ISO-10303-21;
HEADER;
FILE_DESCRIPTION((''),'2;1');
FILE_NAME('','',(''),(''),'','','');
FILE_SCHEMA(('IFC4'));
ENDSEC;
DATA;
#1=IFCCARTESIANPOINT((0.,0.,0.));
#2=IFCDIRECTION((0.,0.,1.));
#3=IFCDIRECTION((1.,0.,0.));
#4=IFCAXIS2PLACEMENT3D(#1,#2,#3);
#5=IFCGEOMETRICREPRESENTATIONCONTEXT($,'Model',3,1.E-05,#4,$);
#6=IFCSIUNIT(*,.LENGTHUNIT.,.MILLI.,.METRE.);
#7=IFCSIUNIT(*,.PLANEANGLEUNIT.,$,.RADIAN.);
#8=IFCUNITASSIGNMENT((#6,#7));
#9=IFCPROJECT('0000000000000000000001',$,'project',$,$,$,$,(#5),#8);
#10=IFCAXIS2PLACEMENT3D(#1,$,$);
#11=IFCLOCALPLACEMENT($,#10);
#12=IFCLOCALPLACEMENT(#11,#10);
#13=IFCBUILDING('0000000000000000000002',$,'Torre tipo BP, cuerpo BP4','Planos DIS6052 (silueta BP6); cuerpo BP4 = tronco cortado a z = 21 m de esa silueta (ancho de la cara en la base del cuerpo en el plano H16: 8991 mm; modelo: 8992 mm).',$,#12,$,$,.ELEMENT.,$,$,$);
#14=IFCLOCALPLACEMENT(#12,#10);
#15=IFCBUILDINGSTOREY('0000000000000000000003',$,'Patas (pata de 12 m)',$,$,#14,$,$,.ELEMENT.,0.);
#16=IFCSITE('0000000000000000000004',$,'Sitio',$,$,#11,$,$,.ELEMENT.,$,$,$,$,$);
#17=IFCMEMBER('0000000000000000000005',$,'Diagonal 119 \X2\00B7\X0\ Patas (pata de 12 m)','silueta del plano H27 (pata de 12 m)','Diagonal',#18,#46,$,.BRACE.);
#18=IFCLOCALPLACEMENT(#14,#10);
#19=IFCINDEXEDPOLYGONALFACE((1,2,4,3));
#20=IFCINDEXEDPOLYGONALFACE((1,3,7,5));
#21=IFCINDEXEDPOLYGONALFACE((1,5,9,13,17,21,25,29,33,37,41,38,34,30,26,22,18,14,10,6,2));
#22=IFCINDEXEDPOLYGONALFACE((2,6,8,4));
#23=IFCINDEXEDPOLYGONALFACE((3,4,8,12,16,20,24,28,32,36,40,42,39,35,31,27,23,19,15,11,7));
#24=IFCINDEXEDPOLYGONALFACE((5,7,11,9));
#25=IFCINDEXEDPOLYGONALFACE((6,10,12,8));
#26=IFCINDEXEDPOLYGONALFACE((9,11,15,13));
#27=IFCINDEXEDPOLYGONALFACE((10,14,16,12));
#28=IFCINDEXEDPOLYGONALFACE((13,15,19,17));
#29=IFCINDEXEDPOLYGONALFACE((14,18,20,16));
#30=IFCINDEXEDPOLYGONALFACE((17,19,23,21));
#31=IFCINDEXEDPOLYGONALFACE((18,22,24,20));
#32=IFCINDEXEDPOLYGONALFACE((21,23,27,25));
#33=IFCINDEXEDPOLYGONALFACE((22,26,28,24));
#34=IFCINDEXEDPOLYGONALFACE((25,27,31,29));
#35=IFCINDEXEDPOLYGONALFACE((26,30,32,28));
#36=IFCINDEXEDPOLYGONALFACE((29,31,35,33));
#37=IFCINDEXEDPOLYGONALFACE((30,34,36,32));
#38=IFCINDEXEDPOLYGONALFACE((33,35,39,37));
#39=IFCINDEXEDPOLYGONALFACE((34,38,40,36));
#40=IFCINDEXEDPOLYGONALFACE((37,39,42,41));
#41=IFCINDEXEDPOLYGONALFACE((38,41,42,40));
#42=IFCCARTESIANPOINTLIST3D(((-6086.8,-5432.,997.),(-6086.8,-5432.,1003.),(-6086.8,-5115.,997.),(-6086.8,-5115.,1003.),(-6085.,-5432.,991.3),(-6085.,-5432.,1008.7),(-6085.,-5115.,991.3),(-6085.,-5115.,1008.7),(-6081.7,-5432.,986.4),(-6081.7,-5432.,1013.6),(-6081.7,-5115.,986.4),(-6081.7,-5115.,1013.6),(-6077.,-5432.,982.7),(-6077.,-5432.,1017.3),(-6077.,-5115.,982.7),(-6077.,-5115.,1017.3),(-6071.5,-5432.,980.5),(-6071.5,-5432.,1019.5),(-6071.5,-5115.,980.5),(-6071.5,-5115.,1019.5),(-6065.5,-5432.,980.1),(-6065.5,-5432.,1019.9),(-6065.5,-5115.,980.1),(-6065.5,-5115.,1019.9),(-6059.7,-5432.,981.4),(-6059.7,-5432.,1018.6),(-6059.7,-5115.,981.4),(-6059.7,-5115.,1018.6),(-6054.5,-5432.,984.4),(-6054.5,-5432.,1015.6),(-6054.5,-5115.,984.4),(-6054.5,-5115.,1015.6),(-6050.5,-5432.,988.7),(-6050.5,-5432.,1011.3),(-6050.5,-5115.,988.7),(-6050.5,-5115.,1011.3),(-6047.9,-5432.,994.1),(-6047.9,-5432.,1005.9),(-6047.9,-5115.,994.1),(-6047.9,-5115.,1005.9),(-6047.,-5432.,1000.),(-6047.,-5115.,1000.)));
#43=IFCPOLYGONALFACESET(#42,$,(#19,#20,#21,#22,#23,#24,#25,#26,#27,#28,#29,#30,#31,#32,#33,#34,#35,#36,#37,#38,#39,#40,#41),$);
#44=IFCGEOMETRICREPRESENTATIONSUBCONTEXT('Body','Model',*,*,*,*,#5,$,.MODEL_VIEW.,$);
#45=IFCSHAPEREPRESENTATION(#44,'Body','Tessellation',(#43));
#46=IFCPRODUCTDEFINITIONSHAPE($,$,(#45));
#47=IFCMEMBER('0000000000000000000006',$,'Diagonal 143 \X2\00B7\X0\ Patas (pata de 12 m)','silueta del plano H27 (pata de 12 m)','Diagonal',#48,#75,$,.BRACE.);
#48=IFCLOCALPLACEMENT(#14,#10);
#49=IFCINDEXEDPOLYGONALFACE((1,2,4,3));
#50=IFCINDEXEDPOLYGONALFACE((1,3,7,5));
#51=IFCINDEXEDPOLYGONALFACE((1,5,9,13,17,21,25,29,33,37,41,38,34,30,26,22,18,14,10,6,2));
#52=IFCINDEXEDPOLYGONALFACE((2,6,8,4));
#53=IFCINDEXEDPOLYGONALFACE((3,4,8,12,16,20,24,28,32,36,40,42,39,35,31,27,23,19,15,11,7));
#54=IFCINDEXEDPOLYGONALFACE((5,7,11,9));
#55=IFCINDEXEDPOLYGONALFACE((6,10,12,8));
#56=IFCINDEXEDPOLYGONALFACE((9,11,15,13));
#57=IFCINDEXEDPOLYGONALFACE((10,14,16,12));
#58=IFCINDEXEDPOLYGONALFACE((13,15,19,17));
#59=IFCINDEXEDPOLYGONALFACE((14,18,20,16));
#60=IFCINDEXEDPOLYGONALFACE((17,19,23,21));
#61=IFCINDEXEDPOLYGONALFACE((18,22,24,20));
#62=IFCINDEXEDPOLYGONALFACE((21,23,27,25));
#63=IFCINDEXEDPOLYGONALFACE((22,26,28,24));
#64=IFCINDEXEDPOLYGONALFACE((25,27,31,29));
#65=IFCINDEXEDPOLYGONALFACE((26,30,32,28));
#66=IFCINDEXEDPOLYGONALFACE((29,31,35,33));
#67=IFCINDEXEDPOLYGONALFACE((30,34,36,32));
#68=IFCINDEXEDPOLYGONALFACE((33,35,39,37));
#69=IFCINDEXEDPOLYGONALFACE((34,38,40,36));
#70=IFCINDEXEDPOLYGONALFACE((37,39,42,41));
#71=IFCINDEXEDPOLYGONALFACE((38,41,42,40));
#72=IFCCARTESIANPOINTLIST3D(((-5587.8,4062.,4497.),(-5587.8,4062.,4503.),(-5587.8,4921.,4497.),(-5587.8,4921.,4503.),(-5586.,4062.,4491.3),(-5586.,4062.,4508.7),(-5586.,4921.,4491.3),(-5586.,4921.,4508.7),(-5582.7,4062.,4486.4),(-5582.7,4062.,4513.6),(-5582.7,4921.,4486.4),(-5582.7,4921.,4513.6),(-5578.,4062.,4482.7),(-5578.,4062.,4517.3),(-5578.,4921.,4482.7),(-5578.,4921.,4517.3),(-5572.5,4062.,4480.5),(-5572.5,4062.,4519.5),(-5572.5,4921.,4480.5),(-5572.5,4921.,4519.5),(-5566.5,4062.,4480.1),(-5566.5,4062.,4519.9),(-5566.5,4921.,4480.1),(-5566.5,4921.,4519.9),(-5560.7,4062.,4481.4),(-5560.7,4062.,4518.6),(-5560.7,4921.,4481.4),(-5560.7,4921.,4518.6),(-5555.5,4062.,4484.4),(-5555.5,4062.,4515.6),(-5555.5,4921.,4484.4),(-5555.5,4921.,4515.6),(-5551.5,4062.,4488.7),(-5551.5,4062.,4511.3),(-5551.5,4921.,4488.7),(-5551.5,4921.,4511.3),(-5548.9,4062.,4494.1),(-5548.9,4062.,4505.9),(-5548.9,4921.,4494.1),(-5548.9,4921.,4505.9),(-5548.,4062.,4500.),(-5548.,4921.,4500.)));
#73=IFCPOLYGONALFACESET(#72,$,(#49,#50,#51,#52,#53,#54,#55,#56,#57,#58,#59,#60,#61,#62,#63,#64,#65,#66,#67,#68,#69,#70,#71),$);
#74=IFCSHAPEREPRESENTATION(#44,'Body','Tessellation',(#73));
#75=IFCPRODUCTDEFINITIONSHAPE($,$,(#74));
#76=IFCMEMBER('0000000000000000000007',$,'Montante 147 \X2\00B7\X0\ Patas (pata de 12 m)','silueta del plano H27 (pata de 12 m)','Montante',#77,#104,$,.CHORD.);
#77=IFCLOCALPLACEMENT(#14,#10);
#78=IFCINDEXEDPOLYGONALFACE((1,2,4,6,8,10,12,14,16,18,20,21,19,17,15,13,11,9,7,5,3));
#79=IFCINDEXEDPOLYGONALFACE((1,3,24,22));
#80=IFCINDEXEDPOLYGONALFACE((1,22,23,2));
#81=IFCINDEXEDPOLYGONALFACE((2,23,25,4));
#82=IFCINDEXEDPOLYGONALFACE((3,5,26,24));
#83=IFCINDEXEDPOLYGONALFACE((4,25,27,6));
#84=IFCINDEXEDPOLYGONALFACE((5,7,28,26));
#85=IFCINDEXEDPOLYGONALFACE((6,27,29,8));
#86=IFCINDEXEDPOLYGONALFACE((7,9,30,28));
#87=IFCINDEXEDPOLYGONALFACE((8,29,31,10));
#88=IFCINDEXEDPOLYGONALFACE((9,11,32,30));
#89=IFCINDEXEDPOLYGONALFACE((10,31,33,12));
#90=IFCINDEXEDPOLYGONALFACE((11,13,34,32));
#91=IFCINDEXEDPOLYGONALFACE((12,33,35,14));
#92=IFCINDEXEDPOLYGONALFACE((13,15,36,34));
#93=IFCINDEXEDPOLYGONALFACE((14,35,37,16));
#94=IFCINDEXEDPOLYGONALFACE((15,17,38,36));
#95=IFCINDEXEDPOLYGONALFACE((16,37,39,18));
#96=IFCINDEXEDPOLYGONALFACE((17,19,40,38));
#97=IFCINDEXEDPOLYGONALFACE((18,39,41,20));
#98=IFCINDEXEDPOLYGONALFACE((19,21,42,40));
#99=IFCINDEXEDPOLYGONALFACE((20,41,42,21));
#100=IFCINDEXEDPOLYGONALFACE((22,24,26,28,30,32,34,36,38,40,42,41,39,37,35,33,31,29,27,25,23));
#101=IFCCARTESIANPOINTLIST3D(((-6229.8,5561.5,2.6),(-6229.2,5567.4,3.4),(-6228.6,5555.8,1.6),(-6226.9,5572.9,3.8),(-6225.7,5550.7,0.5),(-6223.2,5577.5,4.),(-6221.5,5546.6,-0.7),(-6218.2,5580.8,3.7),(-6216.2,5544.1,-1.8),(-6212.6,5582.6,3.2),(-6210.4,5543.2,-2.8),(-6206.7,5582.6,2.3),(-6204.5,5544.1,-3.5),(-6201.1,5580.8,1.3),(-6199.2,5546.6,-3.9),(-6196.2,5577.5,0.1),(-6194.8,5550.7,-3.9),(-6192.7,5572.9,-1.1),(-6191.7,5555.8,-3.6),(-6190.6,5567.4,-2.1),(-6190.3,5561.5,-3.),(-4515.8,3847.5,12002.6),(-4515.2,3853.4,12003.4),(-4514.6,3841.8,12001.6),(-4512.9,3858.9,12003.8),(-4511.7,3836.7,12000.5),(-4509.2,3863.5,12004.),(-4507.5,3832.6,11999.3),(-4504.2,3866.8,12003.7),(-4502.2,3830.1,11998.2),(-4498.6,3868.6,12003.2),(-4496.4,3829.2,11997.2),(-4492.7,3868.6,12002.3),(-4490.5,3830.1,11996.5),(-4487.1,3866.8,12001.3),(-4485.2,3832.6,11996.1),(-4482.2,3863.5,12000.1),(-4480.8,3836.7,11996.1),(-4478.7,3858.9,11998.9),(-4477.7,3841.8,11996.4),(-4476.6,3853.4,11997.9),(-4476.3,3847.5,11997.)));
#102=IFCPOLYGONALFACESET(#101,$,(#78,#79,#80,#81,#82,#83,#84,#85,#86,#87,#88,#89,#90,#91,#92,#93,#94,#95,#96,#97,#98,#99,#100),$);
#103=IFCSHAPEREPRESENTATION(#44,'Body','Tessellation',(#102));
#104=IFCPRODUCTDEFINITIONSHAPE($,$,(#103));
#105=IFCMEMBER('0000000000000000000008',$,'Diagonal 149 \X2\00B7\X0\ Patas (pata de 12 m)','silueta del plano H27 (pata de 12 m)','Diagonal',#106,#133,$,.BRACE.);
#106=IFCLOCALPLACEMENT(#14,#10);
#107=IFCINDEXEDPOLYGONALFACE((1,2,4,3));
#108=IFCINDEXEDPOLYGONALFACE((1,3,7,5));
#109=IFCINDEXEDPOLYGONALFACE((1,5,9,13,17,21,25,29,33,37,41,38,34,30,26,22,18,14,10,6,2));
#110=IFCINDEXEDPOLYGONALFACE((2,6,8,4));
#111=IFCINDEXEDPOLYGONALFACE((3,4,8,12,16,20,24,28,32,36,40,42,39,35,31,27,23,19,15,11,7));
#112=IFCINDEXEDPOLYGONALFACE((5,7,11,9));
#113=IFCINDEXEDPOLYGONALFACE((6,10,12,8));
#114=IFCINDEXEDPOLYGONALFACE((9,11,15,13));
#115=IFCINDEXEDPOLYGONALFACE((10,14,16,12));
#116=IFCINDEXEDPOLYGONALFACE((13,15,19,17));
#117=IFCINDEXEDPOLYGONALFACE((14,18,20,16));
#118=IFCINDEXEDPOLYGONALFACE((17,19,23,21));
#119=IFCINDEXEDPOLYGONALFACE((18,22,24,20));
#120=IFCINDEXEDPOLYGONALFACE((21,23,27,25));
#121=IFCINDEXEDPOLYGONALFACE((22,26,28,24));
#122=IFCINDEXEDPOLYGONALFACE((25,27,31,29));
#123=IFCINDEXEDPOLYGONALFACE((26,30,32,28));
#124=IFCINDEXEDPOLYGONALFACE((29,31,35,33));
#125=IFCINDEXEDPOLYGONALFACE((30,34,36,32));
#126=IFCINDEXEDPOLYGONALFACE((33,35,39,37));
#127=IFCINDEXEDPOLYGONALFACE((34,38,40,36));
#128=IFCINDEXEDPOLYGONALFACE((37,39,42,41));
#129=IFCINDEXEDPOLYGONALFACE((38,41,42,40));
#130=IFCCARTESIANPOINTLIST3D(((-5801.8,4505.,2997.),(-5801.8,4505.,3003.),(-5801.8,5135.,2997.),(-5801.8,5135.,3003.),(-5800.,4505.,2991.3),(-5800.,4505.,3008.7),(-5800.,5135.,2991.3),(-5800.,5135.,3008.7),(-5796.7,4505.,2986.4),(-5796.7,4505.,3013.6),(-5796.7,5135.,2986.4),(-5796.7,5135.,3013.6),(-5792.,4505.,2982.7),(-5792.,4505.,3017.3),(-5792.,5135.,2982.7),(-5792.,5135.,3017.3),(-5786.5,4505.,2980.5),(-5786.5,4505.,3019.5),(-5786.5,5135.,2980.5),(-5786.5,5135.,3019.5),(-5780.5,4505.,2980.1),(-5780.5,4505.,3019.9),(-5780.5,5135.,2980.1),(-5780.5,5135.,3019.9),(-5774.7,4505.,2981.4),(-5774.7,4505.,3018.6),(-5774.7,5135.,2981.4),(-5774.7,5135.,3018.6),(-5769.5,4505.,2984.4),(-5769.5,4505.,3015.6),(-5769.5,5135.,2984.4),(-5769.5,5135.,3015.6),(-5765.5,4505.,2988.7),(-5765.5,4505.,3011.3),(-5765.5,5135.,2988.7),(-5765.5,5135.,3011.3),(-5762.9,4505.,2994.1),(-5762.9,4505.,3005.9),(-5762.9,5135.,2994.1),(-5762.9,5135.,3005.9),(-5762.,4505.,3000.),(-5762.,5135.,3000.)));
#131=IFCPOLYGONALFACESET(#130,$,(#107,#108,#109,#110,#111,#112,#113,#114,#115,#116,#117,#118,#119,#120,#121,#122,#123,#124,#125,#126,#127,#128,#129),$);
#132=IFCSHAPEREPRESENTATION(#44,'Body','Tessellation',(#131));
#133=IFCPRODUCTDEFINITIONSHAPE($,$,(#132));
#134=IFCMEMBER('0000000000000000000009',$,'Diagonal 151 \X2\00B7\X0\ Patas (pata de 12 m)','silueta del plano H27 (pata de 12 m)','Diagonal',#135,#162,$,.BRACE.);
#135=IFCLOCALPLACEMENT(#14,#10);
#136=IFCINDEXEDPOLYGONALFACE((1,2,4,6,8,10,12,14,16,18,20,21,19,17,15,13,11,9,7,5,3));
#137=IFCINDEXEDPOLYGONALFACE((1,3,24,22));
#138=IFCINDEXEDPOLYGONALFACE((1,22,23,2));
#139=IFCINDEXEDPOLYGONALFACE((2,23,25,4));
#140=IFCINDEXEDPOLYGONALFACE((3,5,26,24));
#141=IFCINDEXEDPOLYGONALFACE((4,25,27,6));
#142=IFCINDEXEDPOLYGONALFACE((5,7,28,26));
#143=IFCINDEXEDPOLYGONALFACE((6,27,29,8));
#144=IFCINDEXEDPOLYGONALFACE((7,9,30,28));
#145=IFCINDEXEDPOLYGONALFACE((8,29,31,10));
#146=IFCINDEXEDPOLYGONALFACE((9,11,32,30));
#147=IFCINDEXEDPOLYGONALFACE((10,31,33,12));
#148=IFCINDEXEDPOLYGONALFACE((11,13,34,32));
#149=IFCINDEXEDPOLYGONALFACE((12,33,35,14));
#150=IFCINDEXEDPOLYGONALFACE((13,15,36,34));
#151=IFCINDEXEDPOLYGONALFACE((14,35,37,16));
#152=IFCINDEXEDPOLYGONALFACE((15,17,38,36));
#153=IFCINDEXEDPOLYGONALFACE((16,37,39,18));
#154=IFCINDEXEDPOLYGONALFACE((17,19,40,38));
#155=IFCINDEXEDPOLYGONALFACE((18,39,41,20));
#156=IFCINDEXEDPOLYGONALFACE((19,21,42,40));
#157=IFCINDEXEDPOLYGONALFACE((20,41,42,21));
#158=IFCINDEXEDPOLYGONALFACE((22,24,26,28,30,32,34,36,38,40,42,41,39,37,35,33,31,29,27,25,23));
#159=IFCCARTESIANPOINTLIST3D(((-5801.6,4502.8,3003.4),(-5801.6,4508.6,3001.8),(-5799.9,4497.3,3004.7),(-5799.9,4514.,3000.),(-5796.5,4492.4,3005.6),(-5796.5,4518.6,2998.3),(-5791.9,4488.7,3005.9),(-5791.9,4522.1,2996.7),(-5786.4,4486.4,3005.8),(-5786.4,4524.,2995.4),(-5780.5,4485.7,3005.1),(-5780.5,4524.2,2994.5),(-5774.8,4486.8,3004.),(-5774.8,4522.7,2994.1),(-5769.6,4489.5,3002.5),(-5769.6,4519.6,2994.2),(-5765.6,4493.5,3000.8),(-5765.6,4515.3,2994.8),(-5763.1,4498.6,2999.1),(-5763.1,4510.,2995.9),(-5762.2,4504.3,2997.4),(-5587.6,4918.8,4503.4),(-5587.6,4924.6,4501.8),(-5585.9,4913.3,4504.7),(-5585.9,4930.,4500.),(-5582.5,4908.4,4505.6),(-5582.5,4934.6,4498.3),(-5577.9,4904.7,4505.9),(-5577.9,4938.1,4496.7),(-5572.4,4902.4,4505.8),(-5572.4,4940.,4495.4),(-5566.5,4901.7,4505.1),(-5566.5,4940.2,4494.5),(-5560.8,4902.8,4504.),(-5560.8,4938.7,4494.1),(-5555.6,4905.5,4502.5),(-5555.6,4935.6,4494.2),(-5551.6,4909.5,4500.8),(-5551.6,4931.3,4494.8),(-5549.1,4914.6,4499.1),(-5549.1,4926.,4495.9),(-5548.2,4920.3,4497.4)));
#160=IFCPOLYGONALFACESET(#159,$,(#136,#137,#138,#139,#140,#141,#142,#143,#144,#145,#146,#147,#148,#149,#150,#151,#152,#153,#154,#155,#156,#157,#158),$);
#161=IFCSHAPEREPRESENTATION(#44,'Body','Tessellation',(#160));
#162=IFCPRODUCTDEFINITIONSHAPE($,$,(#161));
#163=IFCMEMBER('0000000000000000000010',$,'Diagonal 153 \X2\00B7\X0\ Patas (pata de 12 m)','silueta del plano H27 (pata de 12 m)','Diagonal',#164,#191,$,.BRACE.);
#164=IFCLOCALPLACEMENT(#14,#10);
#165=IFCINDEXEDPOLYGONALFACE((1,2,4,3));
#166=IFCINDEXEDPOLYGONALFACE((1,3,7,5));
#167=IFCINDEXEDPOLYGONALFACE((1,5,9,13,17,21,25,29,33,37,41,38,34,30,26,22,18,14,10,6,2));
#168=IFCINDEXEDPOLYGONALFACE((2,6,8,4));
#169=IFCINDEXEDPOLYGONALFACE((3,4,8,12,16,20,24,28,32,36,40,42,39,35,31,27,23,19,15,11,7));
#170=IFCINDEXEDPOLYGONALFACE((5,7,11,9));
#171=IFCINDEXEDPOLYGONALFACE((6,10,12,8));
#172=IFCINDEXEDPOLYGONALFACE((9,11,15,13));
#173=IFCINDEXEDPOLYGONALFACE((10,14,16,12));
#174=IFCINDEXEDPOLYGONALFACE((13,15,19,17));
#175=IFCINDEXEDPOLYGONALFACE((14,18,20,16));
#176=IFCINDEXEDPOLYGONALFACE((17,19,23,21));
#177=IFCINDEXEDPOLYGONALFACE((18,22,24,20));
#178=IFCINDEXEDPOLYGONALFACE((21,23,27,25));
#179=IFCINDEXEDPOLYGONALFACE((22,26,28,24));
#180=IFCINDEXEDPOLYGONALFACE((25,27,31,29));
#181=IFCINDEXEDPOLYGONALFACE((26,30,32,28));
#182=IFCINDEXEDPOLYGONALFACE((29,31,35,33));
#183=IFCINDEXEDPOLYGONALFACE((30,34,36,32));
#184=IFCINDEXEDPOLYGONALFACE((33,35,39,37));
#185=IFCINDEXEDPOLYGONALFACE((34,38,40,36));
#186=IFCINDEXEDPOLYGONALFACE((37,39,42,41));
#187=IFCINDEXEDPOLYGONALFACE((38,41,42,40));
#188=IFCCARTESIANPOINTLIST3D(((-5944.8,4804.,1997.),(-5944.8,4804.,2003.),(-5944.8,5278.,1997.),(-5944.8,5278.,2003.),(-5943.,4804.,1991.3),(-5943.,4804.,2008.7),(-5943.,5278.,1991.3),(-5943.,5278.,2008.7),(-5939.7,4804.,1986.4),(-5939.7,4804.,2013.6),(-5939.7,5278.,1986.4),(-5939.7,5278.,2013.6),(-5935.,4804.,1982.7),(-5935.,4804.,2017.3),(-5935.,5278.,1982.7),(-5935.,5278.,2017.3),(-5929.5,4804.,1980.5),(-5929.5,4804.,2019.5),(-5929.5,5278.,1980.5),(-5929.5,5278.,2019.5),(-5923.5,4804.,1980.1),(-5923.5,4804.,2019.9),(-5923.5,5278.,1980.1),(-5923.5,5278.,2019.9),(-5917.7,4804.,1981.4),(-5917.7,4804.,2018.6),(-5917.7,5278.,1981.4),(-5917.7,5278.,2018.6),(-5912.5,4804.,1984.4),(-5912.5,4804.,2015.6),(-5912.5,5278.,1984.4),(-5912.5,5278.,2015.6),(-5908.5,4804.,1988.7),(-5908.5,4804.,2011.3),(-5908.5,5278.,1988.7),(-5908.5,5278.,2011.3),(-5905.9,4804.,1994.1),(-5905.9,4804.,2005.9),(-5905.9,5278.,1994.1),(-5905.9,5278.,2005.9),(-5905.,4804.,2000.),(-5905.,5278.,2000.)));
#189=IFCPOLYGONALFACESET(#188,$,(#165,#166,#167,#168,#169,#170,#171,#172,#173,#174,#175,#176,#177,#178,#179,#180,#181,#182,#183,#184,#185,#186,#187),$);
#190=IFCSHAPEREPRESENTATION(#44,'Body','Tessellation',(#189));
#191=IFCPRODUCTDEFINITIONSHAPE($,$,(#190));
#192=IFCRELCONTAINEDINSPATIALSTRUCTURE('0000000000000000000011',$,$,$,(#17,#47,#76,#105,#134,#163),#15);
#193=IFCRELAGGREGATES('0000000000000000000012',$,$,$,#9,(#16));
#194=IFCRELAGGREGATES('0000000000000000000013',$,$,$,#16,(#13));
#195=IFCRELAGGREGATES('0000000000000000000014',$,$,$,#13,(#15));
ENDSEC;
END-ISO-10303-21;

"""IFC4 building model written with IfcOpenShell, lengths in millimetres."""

from ifc_helpers import new_model, si_unit, frame, origin, origin_with_axes, place, context, subcontext, project, spatial, circle, extrude, element, save


model = new_model("IFC4")

# Units and contexts
model_context = context("Model", 3, precision=1e-05, world=origin_with_axes())
body_context = subcontext(model_context, "Body", "Model", "MODEL_VIEW")
ifc_project = project(units=[si_unit("LENGTHUNIT", "METRE", prefix="MILLI"), si_unit("PLANEANGLEUNIT", "RADIAN")], contexts=[model_context])

# Site, building, storey
site_placement = place(None, origin())
site = spatial("IfcSite", under=ifc_project, at=site_placement, Name="Sitio", CompositionType="ELEMENT")
building_placement = place(site_placement, origin())
building = spatial("IfcBuilding", under=site, at=building_placement, Name="Torre tipo BP, cuerpo BP4", Description="Planos DIS6052 (silueta BP6); cuerpo BP4 = tronco cortado a z = 21 m de esa silueta (ancho de la cara en la base del cuerpo en el plano H16: 8991 mm; modelo: 8992 mm).", CompositionType="ELEMENT")
storey_placement = place(building_placement, origin())
storey = spatial("IfcBuildingStorey", under=building, at=storey_placement, Name="Patas (pata de 12 m)", CompositionType="ELEMENT", Elevation=0.0)

# Members
member_1_placement = place(storey_placement, frame((-6067.0, -5432.0, 1000.0), z_axis=(0.0, 1.0, 0.0), x_axis=(1.0, 0.0, 0.0)))
element("IfcMember", 1, at=member_1_placement, inside=storey, Name="Diagonal 119 · Patas (pata de 12 m)", Description="silueta del plano H27 (pata de 12 m)", ObjectType="Diagonal", PredefinedType="BRACE", context=body_context, shape_type="SweptSolid", body=[
    extrude(circle(Radius=20.0), None, (0.0, 0.0, 1.0), 317.0),
])
member_2_placement = place(storey_placement, frame((-5568.0, 4921.0, 4500.0), z_axis=(0.0, -1.0, 0.0), x_axis=(1.0, 0.0, 0.0)))
element("IfcMember", 2, at=member_2_placement, inside=storey, Name="Diagonal 143 · Patas (pata de 12 m)", Description="silueta del plano H27 (pata de 12 m)", ObjectType="Diagonal", PredefinedType="BRACE", context=body_context, shape_type="SweptSolid", body=[
    extrude(circle(Radius=20.0), None, (0.0, 0.0, 1.0), 859.0),
])
member_3_placement = place(storey_placement, frame((-6210.0, 5563.0, 0.0), z_axis=(0.140006, -0.140006, 0.980202), x_axis=(-0.019797, -0.990151, -0.138599)))
element("IfcMember", 3, at=member_3_placement, inside=storey, Name="Montante 147 · Patas (pata de 12 m)", Description="silueta del plano H27 (pata de 12 m)", ObjectType="Montante", PredefinedType="CHORD", context=body_context, shape_type="SweptSolid", body=[
    extrude(circle(Radius=20.0), None, (0.0, 0.0, 1.0), 12242.4),
])
member_4_placement = place(storey_placement, frame((-5782.0, 5135.0, 3000.0), z_axis=(0.0, -1.0, 0.0), x_axis=(1.0, 0.0, 0.0)))
element("IfcMember", 4, at=member_4_placement, inside=storey, Name="Diagonal 149 · Patas (pata de 12 m)", Description="silueta del plano H27 (pata de 12 m)", ObjectType="Diagonal", PredefinedType="BRACE", context=body_context, shape_type="SweptSolid", body=[
    extrude(circle(Radius=20.0), None, (0.0, 0.0, 1.0), 630.0),
])
member_5_placement = place(storey_placement, frame((-5782.0, 4505.0, 3000.0), z_axis=(0.136197, 0.264756, 0.954649), x_axis=(0.990682, -0.036398, -0.131243)))
element("IfcMember", 5, at=member_5_placement, inside=storey, Name="Diagonal 151 · Patas (pata de 12 m)", Description="silueta del plano H27 (pata de 12 m)", ObjectType="Diagonal", PredefinedType="BRACE", context=body_context, shape_type="SweptSolid", body=[
    extrude(circle(Radius=20.0), None, (0.0, 0.0, 1.0), 1571.3),
])
member_6_placement = place(storey_placement, frame((-5925.0, 5278.0, 2000.0), z_axis=(0.0, -1.0, 0.0), x_axis=(1.0, 0.0, 0.0)))
element("IfcMember", 6, at=member_6_placement, inside=storey, Name="Diagonal 153 · Patas (pata de 12 m)", Description="silueta del plano H27 (pata de 12 m)", ObjectType="Diagonal", PredefinedType="BRACE", context=body_context, shape_type="SweptSolid", body=[
    extrude(circle(Radius=20.0), None, (0.0, 0.0, 1.0), 474.0),
])

save(model, "model.ifc")
